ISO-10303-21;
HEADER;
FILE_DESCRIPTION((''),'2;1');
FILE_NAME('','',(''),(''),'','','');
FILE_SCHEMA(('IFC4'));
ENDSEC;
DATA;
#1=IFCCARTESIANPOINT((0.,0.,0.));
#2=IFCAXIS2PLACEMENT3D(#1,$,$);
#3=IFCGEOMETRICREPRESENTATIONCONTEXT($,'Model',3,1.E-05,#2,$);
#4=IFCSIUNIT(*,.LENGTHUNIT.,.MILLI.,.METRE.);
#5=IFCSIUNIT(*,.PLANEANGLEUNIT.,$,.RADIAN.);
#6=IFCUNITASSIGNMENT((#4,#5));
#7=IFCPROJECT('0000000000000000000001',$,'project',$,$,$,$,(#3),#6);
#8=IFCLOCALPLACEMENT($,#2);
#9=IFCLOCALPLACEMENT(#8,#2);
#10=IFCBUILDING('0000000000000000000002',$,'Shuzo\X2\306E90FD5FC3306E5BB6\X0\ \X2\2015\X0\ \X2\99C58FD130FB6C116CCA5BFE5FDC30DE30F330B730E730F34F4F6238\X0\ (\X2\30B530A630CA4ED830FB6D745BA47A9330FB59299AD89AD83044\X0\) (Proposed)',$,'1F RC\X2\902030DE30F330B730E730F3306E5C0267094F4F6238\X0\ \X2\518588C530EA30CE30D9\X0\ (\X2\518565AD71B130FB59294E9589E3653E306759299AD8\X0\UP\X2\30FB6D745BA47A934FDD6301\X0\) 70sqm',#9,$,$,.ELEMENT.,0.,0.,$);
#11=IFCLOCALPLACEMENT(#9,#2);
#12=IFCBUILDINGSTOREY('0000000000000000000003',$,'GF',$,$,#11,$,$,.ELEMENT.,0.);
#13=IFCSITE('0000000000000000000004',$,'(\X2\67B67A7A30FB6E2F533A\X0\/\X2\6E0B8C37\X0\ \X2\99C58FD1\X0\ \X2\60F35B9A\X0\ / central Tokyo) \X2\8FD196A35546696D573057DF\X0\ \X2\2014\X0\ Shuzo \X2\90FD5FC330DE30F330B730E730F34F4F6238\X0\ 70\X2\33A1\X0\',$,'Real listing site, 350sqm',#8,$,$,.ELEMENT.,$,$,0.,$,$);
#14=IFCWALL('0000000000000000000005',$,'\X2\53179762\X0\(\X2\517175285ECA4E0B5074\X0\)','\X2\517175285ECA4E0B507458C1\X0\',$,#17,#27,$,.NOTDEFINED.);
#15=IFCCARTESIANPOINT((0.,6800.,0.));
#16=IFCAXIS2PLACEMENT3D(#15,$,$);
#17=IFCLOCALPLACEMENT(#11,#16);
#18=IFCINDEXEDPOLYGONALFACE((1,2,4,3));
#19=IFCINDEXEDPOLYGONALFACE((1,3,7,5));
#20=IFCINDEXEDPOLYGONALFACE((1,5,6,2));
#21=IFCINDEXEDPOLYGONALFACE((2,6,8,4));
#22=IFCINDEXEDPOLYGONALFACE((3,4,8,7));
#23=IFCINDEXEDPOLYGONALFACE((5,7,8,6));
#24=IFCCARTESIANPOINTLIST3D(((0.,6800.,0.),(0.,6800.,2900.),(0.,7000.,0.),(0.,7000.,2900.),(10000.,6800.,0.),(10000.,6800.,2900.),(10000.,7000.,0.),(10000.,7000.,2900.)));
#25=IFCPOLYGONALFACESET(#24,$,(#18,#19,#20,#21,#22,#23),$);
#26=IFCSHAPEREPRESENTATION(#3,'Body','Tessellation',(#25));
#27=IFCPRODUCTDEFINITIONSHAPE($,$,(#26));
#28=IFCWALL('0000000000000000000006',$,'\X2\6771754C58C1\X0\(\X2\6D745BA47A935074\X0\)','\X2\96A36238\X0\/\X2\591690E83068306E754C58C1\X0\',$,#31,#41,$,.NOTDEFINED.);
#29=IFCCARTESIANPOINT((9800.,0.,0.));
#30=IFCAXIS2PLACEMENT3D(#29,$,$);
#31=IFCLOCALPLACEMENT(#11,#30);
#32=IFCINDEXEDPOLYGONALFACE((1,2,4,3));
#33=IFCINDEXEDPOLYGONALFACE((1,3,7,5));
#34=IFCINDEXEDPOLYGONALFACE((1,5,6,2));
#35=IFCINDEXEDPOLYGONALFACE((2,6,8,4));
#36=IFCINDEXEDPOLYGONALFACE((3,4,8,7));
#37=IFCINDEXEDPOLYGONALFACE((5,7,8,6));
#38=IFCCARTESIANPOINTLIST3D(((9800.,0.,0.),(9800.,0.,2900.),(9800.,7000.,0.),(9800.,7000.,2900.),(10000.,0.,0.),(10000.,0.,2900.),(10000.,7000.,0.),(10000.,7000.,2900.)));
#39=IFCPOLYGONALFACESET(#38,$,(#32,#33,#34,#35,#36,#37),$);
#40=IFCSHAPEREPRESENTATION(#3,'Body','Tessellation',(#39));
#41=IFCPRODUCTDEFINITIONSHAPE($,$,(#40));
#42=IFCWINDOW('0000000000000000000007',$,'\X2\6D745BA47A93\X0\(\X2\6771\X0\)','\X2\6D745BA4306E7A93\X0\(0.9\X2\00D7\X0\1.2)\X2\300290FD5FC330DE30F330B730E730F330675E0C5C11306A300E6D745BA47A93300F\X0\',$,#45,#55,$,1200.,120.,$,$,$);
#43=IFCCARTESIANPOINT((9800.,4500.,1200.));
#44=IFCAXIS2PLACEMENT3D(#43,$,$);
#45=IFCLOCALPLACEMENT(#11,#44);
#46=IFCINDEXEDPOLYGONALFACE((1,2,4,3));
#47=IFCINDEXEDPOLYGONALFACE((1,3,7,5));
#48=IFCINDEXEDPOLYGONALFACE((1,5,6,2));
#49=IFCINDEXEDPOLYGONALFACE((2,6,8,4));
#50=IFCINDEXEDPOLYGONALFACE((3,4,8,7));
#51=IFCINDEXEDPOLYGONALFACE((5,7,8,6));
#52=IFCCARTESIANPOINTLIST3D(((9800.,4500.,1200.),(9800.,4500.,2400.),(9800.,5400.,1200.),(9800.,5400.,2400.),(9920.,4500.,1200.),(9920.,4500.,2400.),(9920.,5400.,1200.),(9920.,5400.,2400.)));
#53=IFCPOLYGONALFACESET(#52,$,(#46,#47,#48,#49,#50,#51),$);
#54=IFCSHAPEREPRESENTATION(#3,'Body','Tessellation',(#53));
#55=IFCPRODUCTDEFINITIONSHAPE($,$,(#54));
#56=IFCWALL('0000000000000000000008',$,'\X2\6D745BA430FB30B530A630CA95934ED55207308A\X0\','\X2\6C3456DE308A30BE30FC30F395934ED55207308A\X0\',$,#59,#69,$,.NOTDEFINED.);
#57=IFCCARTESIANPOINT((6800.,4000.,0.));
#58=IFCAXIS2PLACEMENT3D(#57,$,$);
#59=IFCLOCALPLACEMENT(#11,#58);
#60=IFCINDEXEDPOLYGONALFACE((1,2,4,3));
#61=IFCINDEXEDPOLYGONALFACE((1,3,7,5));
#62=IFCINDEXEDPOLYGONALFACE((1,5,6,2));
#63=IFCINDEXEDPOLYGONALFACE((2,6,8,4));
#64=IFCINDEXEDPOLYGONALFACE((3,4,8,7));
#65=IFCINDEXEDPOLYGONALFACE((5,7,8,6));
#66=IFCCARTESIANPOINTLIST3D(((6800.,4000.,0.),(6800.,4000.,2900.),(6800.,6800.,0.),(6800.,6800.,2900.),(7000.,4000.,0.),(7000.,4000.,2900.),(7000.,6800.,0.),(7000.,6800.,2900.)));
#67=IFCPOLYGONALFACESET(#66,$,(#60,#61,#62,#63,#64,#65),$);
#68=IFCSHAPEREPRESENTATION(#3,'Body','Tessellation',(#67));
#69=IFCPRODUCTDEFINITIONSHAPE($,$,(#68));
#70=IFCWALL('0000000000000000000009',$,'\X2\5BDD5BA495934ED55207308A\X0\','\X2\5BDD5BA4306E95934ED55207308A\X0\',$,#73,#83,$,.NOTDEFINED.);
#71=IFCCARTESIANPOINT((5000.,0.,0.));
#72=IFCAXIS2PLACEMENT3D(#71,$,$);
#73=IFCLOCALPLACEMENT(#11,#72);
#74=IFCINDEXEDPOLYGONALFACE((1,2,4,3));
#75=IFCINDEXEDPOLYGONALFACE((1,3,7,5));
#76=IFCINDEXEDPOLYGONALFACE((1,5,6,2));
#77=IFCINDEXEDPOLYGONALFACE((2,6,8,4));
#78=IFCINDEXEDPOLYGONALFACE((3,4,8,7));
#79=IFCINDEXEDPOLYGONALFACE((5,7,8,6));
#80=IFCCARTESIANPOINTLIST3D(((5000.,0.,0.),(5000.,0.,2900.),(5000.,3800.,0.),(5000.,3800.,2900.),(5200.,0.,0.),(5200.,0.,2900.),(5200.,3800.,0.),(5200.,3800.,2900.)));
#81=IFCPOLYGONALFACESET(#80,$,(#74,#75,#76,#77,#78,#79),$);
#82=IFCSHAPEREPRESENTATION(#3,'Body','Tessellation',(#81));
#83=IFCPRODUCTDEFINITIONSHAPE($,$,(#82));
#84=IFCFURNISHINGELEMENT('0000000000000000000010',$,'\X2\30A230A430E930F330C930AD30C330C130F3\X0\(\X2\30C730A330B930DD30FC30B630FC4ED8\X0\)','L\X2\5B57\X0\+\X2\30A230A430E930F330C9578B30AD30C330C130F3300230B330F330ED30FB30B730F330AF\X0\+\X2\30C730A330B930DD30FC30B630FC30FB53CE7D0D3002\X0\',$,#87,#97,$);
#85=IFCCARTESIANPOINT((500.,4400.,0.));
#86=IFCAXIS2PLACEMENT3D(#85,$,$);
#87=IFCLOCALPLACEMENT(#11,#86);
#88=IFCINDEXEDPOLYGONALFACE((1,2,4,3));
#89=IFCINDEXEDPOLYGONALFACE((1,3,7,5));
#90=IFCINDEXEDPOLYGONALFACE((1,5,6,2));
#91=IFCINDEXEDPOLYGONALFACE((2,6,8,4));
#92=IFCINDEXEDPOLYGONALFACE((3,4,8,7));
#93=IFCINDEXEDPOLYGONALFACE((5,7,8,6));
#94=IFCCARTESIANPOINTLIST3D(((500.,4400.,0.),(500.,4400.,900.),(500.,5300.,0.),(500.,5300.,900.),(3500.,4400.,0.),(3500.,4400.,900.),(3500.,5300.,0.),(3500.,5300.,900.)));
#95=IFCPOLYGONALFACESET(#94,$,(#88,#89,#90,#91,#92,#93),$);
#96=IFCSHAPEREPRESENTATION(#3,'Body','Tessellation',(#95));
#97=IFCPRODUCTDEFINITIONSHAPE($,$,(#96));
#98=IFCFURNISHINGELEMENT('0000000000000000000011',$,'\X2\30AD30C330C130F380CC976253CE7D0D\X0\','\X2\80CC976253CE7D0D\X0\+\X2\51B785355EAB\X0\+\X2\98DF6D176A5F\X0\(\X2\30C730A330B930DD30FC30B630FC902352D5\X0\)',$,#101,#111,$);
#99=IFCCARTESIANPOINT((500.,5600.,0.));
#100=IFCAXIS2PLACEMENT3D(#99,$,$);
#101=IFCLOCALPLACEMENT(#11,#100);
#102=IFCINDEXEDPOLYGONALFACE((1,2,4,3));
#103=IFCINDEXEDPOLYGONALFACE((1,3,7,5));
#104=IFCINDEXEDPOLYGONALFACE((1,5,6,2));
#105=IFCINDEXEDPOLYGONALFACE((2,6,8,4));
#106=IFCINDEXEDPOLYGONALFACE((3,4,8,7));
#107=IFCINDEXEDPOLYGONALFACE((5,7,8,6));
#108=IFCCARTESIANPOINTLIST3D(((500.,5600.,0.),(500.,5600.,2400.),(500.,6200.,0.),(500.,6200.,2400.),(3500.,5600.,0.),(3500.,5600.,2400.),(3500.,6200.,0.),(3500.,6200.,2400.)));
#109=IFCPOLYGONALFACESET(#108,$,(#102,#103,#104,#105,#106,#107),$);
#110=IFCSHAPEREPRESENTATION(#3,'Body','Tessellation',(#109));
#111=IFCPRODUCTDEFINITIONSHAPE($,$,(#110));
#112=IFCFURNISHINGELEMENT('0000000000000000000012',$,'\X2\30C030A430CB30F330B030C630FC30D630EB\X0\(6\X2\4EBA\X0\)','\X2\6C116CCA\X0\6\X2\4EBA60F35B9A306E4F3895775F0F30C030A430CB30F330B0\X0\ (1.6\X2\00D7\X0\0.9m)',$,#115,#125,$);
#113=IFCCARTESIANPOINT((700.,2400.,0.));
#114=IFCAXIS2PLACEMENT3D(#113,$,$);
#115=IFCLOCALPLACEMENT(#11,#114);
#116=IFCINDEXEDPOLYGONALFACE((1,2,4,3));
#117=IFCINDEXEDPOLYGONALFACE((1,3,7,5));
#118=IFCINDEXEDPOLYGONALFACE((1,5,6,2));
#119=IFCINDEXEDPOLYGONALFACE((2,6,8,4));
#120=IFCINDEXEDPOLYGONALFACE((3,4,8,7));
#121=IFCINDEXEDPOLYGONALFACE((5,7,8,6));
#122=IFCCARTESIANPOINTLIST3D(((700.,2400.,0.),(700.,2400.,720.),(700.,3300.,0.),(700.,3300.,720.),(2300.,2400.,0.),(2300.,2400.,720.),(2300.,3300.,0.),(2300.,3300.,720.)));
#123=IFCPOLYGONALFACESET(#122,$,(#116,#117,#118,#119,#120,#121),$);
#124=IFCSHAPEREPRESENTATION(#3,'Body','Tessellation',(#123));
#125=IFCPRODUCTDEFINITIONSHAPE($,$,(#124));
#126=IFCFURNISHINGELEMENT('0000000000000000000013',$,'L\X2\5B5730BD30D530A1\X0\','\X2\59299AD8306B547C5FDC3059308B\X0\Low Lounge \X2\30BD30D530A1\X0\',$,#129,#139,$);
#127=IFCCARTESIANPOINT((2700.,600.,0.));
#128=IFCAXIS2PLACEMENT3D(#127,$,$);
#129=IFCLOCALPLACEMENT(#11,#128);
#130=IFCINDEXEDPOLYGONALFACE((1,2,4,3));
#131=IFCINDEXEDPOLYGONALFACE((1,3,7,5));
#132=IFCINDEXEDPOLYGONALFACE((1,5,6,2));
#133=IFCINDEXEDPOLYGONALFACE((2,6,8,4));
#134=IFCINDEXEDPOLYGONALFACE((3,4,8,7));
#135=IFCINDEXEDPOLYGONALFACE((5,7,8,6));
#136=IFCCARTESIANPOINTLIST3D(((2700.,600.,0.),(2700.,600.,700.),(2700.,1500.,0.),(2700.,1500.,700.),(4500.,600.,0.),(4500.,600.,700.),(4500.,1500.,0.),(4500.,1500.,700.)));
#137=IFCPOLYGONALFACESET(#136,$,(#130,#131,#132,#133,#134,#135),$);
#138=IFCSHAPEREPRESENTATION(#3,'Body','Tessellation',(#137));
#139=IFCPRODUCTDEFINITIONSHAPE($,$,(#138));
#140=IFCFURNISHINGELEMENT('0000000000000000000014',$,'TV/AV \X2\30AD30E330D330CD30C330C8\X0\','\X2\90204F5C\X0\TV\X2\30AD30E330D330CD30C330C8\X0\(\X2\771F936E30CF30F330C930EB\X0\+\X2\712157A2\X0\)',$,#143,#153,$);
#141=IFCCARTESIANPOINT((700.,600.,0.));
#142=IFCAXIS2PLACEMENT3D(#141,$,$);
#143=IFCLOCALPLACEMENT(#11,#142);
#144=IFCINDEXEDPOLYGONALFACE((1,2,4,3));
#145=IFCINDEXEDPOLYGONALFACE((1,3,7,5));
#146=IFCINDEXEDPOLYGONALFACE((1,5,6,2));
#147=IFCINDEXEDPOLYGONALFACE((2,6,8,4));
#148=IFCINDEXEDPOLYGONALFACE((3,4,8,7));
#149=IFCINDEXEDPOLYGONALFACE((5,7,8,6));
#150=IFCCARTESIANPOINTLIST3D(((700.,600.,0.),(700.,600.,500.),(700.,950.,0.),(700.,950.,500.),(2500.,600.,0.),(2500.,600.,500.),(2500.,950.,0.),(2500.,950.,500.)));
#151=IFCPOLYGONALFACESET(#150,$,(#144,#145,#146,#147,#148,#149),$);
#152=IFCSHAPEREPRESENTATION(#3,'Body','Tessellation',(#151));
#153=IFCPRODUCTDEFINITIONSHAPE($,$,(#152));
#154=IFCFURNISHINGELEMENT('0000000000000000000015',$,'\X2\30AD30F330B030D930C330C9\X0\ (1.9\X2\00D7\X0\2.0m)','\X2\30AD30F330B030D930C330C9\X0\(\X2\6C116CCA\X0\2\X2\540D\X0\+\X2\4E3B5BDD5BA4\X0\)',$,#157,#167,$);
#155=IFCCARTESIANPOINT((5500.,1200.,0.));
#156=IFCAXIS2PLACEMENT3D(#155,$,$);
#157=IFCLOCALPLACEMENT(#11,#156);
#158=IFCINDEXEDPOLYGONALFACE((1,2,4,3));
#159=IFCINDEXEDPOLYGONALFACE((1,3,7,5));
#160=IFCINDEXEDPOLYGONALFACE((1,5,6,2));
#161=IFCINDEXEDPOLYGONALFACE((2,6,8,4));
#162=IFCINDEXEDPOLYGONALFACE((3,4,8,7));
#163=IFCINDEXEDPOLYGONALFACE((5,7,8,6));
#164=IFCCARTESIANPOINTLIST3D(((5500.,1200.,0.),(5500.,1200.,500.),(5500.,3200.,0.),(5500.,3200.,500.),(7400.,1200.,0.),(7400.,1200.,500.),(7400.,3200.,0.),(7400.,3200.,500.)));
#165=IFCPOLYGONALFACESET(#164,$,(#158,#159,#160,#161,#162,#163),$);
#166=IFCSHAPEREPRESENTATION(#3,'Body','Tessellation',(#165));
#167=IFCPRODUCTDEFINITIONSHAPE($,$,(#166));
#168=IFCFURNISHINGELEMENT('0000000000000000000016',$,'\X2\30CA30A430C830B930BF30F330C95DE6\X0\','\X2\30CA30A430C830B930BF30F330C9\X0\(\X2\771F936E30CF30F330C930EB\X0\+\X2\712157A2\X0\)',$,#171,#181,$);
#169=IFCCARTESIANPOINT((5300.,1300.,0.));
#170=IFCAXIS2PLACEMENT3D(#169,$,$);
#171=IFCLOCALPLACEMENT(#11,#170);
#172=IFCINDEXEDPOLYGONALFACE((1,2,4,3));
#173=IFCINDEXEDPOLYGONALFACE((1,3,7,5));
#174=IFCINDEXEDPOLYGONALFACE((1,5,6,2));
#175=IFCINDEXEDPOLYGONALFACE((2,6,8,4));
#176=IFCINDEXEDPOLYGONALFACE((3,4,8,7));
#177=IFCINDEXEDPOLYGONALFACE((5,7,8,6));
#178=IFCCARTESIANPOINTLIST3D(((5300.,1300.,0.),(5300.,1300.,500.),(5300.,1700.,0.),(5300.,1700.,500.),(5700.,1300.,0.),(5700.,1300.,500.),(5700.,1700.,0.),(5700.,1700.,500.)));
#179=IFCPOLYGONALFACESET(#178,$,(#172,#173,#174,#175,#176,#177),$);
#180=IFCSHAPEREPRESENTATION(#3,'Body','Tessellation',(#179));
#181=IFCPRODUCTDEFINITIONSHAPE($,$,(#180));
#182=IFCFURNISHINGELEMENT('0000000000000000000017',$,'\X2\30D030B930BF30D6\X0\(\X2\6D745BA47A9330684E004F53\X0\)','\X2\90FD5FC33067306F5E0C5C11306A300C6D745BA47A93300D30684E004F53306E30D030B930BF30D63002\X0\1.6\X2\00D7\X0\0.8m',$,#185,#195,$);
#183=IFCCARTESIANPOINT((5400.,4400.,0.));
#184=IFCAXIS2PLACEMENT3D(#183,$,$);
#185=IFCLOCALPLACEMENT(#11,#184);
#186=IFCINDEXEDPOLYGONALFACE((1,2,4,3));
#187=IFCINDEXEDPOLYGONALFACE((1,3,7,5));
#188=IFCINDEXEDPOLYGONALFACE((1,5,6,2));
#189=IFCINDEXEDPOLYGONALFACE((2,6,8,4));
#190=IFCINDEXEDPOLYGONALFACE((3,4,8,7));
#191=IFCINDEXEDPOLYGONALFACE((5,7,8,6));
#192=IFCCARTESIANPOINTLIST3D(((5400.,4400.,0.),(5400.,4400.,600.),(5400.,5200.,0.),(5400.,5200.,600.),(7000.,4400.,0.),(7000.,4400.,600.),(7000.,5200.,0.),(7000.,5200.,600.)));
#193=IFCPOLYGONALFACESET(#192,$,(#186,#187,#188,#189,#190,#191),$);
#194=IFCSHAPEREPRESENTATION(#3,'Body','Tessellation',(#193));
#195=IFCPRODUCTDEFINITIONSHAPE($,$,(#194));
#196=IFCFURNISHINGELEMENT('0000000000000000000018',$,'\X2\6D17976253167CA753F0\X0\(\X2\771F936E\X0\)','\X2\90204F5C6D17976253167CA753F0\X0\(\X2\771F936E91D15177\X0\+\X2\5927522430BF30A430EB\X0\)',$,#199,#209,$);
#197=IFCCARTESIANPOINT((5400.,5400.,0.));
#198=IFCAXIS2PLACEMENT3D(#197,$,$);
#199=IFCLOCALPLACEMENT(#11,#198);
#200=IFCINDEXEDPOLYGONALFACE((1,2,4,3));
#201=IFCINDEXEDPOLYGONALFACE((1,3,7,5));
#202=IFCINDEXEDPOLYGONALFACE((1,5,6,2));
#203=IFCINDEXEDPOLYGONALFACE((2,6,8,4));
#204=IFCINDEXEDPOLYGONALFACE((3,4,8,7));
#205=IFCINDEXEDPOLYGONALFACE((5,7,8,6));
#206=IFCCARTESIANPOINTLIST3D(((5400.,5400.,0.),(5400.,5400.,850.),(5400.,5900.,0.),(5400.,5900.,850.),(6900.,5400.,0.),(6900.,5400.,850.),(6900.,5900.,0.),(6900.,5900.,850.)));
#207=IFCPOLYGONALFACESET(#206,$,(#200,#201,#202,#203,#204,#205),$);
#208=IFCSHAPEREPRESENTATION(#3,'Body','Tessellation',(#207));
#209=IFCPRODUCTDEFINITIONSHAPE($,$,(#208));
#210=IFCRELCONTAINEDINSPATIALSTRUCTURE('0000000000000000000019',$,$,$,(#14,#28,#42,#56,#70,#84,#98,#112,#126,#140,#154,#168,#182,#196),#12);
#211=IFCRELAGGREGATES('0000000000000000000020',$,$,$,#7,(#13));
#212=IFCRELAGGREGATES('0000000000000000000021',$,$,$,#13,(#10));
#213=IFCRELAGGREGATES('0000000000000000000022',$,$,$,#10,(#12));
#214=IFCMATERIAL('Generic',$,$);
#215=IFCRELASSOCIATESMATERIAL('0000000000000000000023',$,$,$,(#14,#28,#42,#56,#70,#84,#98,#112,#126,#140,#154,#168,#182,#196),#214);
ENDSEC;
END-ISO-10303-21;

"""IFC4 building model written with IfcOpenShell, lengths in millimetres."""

from ifc_helpers import new_model, si_unit, frame, frame_2d, origin, place, context, project, spatial, rectangle, extrude, material, element, fill, save


model = new_model("IFC4")

# Units and contexts
model_context = context("Model", 3, precision=1e-05, world=origin())
ifc_project = project(units=[si_unit("LENGTHUNIT", "METRE", prefix="MILLI"), si_unit("PLANEANGLEUNIT", "RADIAN")], contexts=[model_context])

# Site, building, storey
site_placement = place(None, origin())
site = spatial("IfcSite", under=ifc_project, at=site_placement, Name="(架空・港区/渋谷 駅近 想定 / central Tokyo) 近隣商業地域 — Shuzo 都心マンション住戸 70㎡", ObjectType="Real listing site, 350sqm", CompositionType="ELEMENT", RefElevation=0.0)
building_placement = place(site_placement, origin())
building = spatial("IfcBuilding", under=site, at=building_placement, Name="Shuzoの都心の家 ― 駅近・民泊対応マンション住戸 (サウナ付・浴室窓・天高高い) (Proposed)", ObjectType="1F RC造マンションの専有住戸 内装リノベ (内断熱・天井解放で天高UP・浴室窓保持) 70sqm", CompositionType="ELEMENT", ElevationOfRefHeight=0.0, ElevationOfTerrain=0.0)
storey_placement = place(building_placement, origin())
storey = spatial("IfcBuildingStorey", under=building, at=storey_placement, Name="GF", CompositionType="ELEMENT", Elevation=0.0)

# Shared definitions
ifc_material = material(Name="Generic")

# Wall
wall_1_placement = place(storey_placement, frame((0.0, 6800.0, 0.0)))
element("IfcWall", 1, at=wall_1_placement, inside=storey, material=ifc_material, Name="北面(共用廊下側)", Description="共用廊下側壁", PredefinedType="NOTDEFINED", context=model_context, shape_type="SweptSolid", body=[
    extrude(rectangle(XDim=10000.0, YDim=200.0, at=frame_2d((5000.0, 100.0))), frame((0.0, 6800.0, 0.0)), (0.0, 0.0, 1.0), 2900.0),
])

# Wall, opening, window
wall_2_placement = place(storey_placement, frame((9800.0, 0.0, 0.0)))
wall_2 = element("IfcWall", 2, at=wall_2_placement, inside=storey, material=ifc_material, Name="東界壁(浴室窓側)", Description="隣戸/外部との界壁", PredefinedType="NOTDEFINED", context=model_context, shape_type="SweptSolid", body=[
    extrude(rectangle(XDim=200.0, YDim=7000.0, at=frame_2d((100.0, 3500.0))), frame((9800.0, 0.0, 0.0)), (0.0, 0.0, 1.0), 2900.0),
])
opening_1_placement = place(storey_placement, frame((9800.0, 4500.0, 1200.0)))
opening_1 = element("IfcOpeningElement", 3, at=opening_1_placement, cuts=wall_2, PredefinedType="NOTDEFINED", context=model_context, shape_type="SweptSolid", body=[
    extrude(rectangle(XDim=120.0, YDim=900.0, at=frame_2d((60.0, 450.0))), frame((9800.0, 4500.0, 1200.0)), (0.0, 0.0, 1.0), 1200.0),
])
window_1_placement = place(storey_placement, frame((9800.0, 4500.0, 1200.0)))
window_1 = element("IfcWindow", 4, at=window_1_placement, inside=storey, material=ifc_material, Name="浴室窓(東)", Description="浴室の窓(0.9×1.2)。都心マンションで希少な『浴室窓』", OverallHeight=1200.0, OverallWidth=120.0, context=model_context, shape_type="SweptSolid", body=[
    extrude(rectangle(XDim=120.0, YDim=900.0, at=frame_2d((60.0, 450.0))), frame((9800.0, 4500.0, 1200.0)), (0.0, 0.0, 1.0), 1200.0),
])
fill(opening_1, window_1)

# Walls
wall_3_placement = place(storey_placement, frame((6800.0, 4000.0, 0.0)))
element("IfcWall", 5, at=wall_3_placement, inside=storey, material=ifc_material, Name="浴室・サウナ間仕切り", Description="水回りゾーン間仕切り", PredefinedType="NOTDEFINED", context=model_context, shape_type="SweptSolid", body=[
    extrude(rectangle(XDim=200.0, YDim=2800.0, at=frame_2d((100.0, 1400.0))), frame((6800.0, 4000.0, 0.0)), (0.0, 0.0, 1.0), 2900.0),
])
wall_4_placement = place(storey_placement, frame((5000.0, 0.0, 0.0)))
element("IfcWall", 6, at=wall_4_placement, inside=storey, material=ifc_material, Name="寝室間仕切り", Description="寝室の間仕切り", PredefinedType="NOTDEFINED", context=model_context, shape_type="SweptSolid", body=[
    extrude(rectangle(XDim=200.0, YDim=3800.0, at=frame_2d((100.0, 1900.0))), frame((5000.0, 0.0, 0.0)), (0.0, 0.0, 1.0), 2900.0),
])

# Furnishing elements
furnishing_1_placement = place(storey_placement, frame((500.0, 4400.0, 0.0)))
element("IfcFurnishingElement", 7, at=furnishing_1_placement, inside=storey, material=ifc_material, Name="アイランドキッチン(ディスポーザー付)", Description="L字+アイランド型キッチン。コンロ・シンク+ディスポーザー・収納。", context=model_context, shape_type="SweptSolid", body=[
    extrude(rectangle(XDim=3000.0, YDim=900.0, at=frame_2d((1500.0, 450.0))), frame((500.0, 4400.0, 0.0)), (0.0, 0.0, 1.0), 900.0),
])
furnishing_2_placement = place(storey_placement, frame((500.0, 5600.0, 0.0)))
element("IfcFurnishingElement", 8, at=furnishing_2_placement, inside=storey, material=ifc_material, Name="キッチン背面収納", Description="背面収納+冷蔵庫+食洗機(ディスポーザー連動)", context=model_context, shape_type="SweptSolid", body=[
    extrude(rectangle(XDim=3000.0, YDim=600.0, at=frame_2d((1500.0, 300.0))), frame((500.0, 5600.0, 0.0)), (0.0, 0.0, 1.0), 2400.0),
])
furnishing_3_placement = place(storey_placement, frame((700.0, 2400.0, 0.0)))
element("IfcFurnishingElement", 9, at=furnishing_3_placement, inside=storey, material=ifc_material, Name="ダイニングテーブル(6人)", Description="民泊6人想定の伸長式ダイニング (1.6×0.9m)", context=model_context, shape_type="SweptSolid", body=[
    extrude(rectangle(XDim=1600.0, YDim=900.0, at=frame_2d((800.0, 450.0))), frame((700.0, 2400.0, 0.0)), (0.0, 0.0, 1.0), 720.0),
])
furnishing_4_placement = place(storey_placement, frame((2700.0, 600.0, 0.0)))
element("IfcFurnishingElement", 10, at=furnishing_4_placement, inside=storey, material=ifc_material, Name="L字ソファ", Description="天高に呼応するLow Lounge ソファ", context=model_context, shape_type="SweptSolid", body=[
    extrude(rectangle(XDim=1800.0, YDim=900.0, at=frame_2d((900.0, 450.0))), frame((2700.0, 600.0, 0.0)), (0.0, 0.0, 1.0), 700.0),
])
furnishing_5_placement = place(storey_placement, frame((700.0, 600.0, 0.0)))
element("IfcFurnishingElement", 11, at=furnishing_5_placement, inside=storey, material=ifc_material, Name="TV/AV キャビネット", Description="造作TVキャビネット(真鍮ハンドル+無垢)", context=model_context, shape_type="SweptSolid", body=[
    extrude(rectangle(XDim=1800.0, YDim=350.0, at=frame_2d((900.0, 175.0))), frame((700.0, 600.0, 0.0)), (0.0, 0.0, 1.0), 500.0),
])
furnishing_6_placement = place(storey_placement, frame((5500.0, 1200.0, 0.0)))
element("IfcFurnishingElement", 12, at=furnishing_6_placement, inside=storey, material=ifc_material, Name="キングベッド (1.9×2.0m)", Description="キングベッド(民泊2名+主寝室)", context=model_context, shape_type="SweptSolid", body=[
    extrude(rectangle(XDim=1900.0, YDim=2000.0, at=frame_2d((950.0, 1000.0))), frame((5500.0, 1200.0, 0.0)), (0.0, 0.0, 1.0), 500.0),
])
furnishing_7_placement = place(storey_placement, frame((5300.0, 1300.0, 0.0)))
element("IfcFurnishingElement", 13, at=furnishing_7_placement, inside=storey, material=ifc_material, Name="ナイトスタンド左", Description="ナイトスタンド(真鍮ハンドル+無垢)", context=model_context, shape_type="SweptSolid", body=[
    extrude(rectangle(XDim=400.0, YDim=400.0, at=frame_2d((200.0, 200.0))), frame((5300.0, 1300.0, 0.0)), (0.0, 0.0, 1.0), 500.0),
])
furnishing_8_placement = place(storey_placement, frame((5400.0, 4400.0, 0.0)))
element("IfcFurnishingElement", 14, at=furnishing_8_placement, inside=storey, material=ifc_material, Name="バスタブ(浴室窓と一体)", Description="都心では希少な「浴室窓」と一体のバスタブ。1.6×0.8m", context=model_context, shape_type="SweptSolid", body=[
    extrude(rectangle(XDim=1600.0, YDim=800.0, at=frame_2d((800.0, 400.0))), frame((5400.0, 4400.0, 0.0)), (0.0, 0.0, 1.0), 600.0),
])
furnishing_9_placement = place(storey_placement, frame((5400.0, 5400.0, 0.0)))
element("IfcFurnishingElement", 15, at=furnishing_9_placement, inside=storey, material=ifc_material, Name="洗面化粧台(真鍮)", Description="造作洗面化粧台(真鍮金具+大判タイル)", context=model_context, shape_type="SweptSolid", body=[
    extrude(rectangle(XDim=1500.0, YDim=500.0, at=frame_2d((750.0, 250.0))), frame((5400.0, 5400.0, 0.0)), (0.0, 0.0, 1.0), 850.0),
])

save(model, "model.ifc")
